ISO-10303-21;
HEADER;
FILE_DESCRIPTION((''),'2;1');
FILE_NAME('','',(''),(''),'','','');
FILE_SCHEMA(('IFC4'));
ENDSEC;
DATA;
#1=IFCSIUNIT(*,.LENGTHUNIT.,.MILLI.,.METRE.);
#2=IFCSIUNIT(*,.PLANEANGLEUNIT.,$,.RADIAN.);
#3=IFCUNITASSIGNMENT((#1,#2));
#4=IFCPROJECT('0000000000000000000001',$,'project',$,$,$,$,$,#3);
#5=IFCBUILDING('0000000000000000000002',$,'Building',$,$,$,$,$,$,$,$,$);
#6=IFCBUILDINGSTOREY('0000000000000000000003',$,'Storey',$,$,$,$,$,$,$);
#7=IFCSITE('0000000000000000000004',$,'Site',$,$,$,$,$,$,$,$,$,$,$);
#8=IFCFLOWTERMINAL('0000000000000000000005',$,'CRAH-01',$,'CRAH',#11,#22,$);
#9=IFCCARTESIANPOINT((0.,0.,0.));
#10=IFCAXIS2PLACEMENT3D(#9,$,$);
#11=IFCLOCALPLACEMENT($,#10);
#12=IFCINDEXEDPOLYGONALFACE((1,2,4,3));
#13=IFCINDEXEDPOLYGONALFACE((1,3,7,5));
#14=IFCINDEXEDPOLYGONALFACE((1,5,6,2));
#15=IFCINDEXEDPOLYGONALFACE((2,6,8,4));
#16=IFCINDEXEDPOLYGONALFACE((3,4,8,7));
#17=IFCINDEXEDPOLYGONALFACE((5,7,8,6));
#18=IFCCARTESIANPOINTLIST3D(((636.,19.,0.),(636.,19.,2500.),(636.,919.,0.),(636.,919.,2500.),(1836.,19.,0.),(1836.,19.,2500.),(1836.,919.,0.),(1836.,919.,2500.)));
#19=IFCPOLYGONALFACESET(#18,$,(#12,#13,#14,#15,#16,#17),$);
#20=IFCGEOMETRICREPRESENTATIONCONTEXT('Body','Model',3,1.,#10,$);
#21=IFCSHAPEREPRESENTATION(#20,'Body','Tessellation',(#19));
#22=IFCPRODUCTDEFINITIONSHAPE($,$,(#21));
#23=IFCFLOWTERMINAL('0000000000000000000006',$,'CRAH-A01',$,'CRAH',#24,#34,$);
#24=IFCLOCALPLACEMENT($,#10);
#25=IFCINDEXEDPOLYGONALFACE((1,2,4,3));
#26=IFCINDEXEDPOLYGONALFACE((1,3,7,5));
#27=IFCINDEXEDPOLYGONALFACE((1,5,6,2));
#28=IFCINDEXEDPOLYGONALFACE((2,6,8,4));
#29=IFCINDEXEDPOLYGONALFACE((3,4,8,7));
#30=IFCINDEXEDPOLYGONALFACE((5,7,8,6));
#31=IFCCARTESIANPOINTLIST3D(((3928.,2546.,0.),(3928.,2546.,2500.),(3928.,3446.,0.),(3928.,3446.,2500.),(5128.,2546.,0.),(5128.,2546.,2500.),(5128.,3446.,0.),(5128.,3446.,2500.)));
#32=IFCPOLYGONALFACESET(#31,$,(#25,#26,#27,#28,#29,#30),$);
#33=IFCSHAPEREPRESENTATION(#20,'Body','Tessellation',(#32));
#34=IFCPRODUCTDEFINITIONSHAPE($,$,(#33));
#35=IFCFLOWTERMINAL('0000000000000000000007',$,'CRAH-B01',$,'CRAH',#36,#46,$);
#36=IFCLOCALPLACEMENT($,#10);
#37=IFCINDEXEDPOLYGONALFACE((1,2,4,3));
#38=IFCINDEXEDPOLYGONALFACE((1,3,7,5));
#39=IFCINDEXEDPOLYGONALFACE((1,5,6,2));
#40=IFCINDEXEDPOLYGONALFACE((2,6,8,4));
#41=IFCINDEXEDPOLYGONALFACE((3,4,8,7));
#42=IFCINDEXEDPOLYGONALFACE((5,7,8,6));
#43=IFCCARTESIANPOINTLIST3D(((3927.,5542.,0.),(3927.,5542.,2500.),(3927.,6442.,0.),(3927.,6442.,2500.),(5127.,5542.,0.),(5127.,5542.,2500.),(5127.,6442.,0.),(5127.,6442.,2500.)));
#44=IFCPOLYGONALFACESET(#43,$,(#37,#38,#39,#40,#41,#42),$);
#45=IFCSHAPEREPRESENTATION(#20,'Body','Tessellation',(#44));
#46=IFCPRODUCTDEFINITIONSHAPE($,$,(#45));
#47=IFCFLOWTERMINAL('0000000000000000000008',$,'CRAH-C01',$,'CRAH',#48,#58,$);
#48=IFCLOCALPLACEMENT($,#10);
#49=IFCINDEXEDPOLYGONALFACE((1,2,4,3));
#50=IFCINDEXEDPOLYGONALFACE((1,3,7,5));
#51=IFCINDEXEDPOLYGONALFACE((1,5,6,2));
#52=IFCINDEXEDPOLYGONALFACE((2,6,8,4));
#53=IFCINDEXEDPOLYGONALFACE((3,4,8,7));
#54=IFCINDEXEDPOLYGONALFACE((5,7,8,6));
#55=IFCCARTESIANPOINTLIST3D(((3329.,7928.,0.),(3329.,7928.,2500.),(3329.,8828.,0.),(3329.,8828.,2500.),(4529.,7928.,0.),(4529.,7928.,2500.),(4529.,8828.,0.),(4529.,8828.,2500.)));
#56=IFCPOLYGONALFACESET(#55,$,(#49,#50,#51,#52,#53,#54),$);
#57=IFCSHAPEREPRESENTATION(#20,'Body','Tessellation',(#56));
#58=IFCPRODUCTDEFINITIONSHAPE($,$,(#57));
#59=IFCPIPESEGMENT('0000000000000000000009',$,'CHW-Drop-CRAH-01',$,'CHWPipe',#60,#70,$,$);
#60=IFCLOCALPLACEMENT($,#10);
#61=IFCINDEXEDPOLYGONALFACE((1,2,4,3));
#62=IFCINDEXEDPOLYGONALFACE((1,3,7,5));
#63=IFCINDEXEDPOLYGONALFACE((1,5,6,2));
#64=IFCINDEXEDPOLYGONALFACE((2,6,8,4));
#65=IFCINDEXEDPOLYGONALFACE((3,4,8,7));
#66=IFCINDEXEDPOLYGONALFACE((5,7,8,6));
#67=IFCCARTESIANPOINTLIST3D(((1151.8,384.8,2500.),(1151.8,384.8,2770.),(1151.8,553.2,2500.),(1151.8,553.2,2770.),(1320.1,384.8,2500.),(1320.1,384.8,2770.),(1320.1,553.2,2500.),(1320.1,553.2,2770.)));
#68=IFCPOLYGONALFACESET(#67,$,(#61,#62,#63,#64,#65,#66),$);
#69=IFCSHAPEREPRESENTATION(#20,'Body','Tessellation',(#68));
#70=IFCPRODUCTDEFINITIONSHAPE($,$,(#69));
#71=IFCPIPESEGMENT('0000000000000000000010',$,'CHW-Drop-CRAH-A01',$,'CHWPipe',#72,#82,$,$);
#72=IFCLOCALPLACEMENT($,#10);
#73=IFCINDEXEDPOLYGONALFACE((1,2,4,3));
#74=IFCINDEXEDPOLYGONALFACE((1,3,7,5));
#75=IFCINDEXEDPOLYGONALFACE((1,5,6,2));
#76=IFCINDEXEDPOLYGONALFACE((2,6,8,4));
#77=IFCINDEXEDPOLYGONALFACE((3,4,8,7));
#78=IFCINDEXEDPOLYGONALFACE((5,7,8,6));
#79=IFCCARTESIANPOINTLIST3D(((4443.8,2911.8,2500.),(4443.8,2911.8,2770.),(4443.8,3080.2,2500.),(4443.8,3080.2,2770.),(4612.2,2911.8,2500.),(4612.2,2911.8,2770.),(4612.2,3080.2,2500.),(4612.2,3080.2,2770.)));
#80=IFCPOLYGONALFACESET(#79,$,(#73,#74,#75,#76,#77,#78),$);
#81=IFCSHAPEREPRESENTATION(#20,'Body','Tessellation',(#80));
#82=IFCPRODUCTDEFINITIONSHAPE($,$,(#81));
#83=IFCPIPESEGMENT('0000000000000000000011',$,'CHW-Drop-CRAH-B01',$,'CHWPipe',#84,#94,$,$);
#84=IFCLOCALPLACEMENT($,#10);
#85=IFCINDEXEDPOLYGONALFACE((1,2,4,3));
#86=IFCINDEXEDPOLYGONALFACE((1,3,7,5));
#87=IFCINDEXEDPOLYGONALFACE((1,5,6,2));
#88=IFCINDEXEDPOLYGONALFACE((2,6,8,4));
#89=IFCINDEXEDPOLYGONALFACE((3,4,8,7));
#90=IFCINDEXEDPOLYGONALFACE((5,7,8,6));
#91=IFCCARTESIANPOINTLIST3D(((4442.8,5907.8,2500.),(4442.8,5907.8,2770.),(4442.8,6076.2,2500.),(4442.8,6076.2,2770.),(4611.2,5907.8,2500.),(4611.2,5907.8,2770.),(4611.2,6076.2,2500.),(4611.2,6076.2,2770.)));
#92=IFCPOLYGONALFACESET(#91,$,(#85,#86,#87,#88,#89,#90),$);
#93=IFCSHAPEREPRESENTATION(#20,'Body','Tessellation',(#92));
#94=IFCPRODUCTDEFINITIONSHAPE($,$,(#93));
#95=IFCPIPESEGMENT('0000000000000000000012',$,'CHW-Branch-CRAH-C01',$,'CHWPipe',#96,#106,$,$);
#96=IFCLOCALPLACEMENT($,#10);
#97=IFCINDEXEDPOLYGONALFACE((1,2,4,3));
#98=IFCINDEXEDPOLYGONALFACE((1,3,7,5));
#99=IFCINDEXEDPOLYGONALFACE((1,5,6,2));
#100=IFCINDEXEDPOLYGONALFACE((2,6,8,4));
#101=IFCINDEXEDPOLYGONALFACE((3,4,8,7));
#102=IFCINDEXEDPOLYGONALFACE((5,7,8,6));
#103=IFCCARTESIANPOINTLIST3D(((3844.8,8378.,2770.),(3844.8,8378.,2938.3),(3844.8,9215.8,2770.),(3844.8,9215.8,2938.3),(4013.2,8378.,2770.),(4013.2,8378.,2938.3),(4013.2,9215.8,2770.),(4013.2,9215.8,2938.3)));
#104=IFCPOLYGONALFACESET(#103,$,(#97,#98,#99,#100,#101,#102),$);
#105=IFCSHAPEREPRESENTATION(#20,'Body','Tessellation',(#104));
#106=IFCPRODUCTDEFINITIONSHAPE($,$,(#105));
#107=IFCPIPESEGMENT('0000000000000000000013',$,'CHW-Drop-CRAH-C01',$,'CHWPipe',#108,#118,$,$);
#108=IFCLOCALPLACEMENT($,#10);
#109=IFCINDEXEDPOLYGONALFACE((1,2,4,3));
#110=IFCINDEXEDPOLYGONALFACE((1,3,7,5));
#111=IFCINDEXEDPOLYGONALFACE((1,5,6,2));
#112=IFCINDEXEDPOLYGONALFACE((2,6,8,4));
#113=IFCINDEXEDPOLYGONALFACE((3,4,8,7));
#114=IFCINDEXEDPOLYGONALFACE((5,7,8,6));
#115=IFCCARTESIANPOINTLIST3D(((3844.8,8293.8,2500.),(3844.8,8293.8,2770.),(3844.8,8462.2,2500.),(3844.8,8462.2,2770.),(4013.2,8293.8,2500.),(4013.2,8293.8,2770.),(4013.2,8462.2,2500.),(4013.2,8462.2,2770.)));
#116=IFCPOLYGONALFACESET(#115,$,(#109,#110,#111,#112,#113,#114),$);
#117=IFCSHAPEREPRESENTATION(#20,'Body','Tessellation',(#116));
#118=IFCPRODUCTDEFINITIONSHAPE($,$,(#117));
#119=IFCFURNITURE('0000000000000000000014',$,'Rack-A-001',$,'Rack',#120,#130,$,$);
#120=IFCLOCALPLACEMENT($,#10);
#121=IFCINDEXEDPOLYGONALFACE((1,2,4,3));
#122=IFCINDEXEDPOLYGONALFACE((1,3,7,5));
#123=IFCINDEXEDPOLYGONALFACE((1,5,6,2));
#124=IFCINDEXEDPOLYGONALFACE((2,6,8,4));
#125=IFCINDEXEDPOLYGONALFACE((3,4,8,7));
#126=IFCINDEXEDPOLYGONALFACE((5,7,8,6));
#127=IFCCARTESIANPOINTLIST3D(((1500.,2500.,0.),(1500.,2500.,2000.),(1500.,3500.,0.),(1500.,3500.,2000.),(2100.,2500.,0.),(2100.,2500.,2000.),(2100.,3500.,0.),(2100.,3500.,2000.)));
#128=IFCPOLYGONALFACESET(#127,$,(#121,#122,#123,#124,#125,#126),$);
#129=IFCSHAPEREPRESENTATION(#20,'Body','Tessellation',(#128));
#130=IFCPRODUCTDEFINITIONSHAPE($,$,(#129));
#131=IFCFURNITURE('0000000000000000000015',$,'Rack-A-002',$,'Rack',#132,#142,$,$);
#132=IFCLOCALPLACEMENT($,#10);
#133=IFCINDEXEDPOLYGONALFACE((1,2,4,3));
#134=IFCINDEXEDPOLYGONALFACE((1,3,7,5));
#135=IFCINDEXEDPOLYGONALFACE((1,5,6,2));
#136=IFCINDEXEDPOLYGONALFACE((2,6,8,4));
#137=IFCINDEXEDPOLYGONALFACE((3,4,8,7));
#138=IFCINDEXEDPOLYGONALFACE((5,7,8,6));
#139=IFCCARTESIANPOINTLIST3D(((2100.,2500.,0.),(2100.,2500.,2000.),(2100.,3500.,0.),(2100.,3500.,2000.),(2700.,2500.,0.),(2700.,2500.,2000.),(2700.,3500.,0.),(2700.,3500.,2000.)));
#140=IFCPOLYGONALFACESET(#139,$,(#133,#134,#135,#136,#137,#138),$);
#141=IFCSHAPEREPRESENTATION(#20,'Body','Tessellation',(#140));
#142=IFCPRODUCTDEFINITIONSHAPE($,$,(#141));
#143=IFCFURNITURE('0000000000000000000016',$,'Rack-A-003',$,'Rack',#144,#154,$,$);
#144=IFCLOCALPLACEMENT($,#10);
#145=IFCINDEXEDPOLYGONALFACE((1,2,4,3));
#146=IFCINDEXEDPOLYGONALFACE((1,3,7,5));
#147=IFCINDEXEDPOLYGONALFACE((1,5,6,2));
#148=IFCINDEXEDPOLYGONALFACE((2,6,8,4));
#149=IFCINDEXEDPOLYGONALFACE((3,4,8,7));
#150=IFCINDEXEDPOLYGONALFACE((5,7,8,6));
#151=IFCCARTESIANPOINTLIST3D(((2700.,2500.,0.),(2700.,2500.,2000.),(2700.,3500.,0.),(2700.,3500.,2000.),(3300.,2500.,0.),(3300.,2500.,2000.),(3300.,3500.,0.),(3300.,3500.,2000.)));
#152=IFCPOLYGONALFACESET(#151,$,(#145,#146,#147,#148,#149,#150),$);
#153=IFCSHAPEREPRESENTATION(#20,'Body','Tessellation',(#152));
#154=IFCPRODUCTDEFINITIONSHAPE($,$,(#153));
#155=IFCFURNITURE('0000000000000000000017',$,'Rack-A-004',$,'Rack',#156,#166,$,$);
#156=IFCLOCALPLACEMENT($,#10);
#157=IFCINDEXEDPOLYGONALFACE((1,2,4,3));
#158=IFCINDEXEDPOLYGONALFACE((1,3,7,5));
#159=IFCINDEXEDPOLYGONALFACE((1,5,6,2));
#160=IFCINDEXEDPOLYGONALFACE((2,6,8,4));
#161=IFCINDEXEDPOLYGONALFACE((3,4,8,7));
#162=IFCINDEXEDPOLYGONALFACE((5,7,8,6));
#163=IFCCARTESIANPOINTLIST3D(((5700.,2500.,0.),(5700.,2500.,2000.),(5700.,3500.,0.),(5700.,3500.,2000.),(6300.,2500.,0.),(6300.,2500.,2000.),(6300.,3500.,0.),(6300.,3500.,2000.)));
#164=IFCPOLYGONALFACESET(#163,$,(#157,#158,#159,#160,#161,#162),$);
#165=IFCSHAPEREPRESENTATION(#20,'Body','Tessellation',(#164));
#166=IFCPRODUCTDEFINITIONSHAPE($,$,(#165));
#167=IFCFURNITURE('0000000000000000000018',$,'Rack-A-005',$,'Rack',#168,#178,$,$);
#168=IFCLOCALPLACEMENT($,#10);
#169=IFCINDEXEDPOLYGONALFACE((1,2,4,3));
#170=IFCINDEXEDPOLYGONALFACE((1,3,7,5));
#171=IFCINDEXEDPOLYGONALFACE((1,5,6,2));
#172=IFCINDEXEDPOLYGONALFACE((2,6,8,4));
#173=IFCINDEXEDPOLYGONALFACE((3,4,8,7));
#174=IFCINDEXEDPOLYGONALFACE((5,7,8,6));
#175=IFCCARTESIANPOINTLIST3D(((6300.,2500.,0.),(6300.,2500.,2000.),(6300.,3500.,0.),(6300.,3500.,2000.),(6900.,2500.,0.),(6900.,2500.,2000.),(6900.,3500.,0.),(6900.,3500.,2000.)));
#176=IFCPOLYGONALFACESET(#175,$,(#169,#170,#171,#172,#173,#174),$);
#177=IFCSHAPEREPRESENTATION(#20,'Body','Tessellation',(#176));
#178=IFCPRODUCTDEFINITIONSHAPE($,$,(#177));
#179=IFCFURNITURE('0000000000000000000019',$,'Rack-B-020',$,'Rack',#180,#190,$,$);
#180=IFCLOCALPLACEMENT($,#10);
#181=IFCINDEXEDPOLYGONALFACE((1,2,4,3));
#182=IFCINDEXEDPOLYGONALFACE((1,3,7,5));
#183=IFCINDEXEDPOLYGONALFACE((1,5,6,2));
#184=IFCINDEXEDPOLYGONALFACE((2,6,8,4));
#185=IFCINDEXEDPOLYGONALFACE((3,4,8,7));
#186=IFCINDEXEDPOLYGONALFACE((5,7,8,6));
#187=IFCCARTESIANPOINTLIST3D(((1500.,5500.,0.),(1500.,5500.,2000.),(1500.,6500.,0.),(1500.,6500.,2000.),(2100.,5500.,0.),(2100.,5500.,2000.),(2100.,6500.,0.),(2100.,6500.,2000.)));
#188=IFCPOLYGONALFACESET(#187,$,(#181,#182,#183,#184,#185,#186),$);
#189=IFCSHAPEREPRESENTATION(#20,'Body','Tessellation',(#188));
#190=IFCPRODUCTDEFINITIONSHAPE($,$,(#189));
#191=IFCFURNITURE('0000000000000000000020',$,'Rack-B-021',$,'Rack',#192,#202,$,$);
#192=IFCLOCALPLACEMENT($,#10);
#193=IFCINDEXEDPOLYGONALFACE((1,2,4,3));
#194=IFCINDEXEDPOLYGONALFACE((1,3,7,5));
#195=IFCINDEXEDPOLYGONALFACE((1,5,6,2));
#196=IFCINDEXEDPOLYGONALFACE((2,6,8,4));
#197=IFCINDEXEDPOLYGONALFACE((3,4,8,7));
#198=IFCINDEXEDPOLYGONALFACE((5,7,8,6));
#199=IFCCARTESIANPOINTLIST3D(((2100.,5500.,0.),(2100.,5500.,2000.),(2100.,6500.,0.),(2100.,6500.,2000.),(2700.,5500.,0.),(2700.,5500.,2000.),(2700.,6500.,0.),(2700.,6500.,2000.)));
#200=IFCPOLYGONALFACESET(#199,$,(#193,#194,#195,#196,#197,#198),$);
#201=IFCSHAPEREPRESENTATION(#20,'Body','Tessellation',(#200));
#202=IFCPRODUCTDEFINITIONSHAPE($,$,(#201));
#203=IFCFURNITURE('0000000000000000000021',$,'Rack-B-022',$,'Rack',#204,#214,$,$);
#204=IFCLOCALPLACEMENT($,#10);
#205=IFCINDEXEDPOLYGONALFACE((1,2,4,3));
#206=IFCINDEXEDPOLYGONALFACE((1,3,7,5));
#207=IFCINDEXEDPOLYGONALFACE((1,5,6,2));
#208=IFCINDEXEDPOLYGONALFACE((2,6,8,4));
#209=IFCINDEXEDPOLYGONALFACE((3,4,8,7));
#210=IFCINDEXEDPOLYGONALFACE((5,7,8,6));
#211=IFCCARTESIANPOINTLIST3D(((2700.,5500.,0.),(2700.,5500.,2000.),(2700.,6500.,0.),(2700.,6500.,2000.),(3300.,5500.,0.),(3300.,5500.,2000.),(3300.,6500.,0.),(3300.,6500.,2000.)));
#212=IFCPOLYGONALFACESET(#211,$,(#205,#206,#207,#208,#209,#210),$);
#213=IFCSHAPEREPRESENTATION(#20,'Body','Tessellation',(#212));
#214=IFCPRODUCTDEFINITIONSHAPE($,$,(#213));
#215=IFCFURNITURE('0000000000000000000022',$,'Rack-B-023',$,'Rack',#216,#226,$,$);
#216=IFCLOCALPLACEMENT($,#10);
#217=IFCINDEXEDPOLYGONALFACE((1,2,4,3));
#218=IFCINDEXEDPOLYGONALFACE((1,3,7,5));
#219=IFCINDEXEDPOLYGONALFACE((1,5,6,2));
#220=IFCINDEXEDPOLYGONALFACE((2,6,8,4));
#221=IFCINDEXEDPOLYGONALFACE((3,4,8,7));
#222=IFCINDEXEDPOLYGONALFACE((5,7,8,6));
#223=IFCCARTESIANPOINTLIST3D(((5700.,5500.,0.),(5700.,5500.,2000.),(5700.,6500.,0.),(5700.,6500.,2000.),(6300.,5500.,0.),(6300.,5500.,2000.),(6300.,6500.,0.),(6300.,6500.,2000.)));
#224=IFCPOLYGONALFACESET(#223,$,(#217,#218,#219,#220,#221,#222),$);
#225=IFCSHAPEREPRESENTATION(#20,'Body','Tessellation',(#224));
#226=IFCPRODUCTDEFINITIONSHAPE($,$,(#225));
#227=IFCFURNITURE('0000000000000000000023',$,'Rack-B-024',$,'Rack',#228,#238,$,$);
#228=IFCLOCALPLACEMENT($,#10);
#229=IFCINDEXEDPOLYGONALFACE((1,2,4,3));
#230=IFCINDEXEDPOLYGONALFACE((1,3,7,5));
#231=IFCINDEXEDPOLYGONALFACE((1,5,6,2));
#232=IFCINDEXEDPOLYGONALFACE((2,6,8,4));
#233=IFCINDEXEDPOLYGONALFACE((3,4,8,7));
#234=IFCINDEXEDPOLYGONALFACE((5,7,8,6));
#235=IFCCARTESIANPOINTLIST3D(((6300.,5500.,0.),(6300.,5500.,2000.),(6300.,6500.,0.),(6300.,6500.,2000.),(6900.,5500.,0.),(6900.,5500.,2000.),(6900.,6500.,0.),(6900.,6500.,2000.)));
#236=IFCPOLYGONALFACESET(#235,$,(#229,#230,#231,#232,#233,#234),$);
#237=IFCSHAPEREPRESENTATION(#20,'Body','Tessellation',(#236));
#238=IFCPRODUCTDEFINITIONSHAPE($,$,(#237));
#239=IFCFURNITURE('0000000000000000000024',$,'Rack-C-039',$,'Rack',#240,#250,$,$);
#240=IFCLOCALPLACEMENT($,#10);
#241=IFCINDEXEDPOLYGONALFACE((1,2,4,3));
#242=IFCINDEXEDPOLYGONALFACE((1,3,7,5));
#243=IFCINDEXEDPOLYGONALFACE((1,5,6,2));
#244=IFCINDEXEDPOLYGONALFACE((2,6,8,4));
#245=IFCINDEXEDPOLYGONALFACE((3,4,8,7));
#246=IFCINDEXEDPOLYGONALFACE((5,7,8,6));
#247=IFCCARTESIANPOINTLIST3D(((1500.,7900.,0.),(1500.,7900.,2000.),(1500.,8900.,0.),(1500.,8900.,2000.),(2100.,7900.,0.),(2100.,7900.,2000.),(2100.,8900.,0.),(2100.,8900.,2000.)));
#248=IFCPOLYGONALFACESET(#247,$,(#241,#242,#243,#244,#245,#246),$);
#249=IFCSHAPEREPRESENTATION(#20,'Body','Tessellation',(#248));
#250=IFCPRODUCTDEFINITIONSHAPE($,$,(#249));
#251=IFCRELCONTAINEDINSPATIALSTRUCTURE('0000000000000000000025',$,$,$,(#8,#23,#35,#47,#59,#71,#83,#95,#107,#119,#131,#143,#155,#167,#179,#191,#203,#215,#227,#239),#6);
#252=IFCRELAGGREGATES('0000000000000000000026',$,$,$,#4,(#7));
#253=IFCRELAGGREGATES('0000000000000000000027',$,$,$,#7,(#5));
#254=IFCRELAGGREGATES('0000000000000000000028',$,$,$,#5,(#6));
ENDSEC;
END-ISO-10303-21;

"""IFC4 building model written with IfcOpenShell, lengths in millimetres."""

from ifc_helpers import new_model, si_unit, frame, origin, place, context, project, spatial, rectangle, extrude, element, save


model = new_model("IFC4")

# Units and contexts
model_context = context("Model", 3, precision=1.0, world=origin(), identifier="Body")
ifc_project = project(units=[si_unit("LENGTHUNIT", "METRE", prefix="MILLI"), si_unit("PLANEANGLEUNIT", "RADIAN")])

# Site, building, storey
site = spatial("IfcSite", under=ifc_project, Name="Site")
building = spatial("IfcBuilding", under=site, Name="Building")
storey = spatial("IfcBuildingStorey", under=building, Name="Storey")

# Flow terminals
for number, where, z_axis, x_axis, name in (
    (1, (1236.0, 469.0, 0.0), (0.0, 0.0, 1.0), (1.0, 0.0, 0.0), "CRAH-01"),
    (2, (4528.0, 2996.0, 0.0), (0.0, 0.0, 1.0), (1.0, 0.0, 0.0), "CRAH-A01"),
    (3, (4527.0, 5992.0, 0.0), (0.0, 0.0, 1.0), (1.0, 0.0, 0.0), "CRAH-B01"),
    (4, (3929.0, 8378.0, 0.0), (0.0, 0.0, 1.0), (1.0, 0.0, 0.0), "CRAH-C01"),
):
    element("IfcFlowTerminal", number, at=place(None, frame(where, z_axis=z_axis, x_axis=x_axis)), inside=storey, Name=name, ObjectType="CRAH", context=model_context, shape_type="SweptSolid", body=[
        extrude(rectangle(XDim=1200.0, YDim=900.0), origin(), (0.0, 0.0, 1.0), 2500.0),
    ])

# Pipe segments
for number, where, z_axis, x_axis, name in (
    (5, (1236.0, 469.0, 2500.0), (0.0, 0.0, 1.0), (1.0, 0.0, 0.0), "CHW-Drop-CRAH-01"),
    (6, (4528.0, 2996.0, 2500.0), (0.0, 0.0, 1.0), (1.0, 0.0, 0.0), "CHW-Drop-CRAH-A01"),
    (7, (4527.0, 5992.0, 2500.0), (0.0, 0.0, 1.0), (1.0, 0.0, 0.0), "CHW-Drop-CRAH-B01"),
):
    element("IfcPipeSegment", number, at=place(None, frame(where, z_axis=z_axis, x_axis=x_axis)), inside=storey, Name=name, ObjectType="CHWPipe", context=model_context, shape_type="SweptSolid", body=[
        extrude(rectangle(XDim=168.3, YDim=168.3), origin(), (0.0, 0.0, 1.0), 270.0),
    ])
pipe_segment_1_placement = place(None, frame((3929.0, 8796.9, 2770.0), z_axis=(0.0, 0.0, 1.0), x_axis=(1.0, 0.0, 0.0)))
element("IfcPipeSegment", 8, at=pipe_segment_1_placement, inside=storey, Name="CHW-Branch-CRAH-C01", ObjectType="CHWPipe", context=model_context, shape_type="SweptSolid", body=[
    extrude(rectangle(XDim=168.3, YDim=837.9), origin(), (0.0, 0.0, 1.0), 168.3),
])
pipe_segment_2_placement = place(None, frame((3929.0, 8378.0, 2500.0), z_axis=(0.0, 0.0, 1.0), x_axis=(1.0, 0.0, 0.0)))
element("IfcPipeSegment", 9, at=pipe_segment_2_placement, inside=storey, Name="CHW-Drop-CRAH-C01", ObjectType="CHWPipe", context=model_context, shape_type="SweptSolid", body=[
    extrude(rectangle(XDim=168.3, YDim=168.3), origin(), (0.0, 0.0, 1.0), 270.0),
])

# Furniture
for number, where, z_axis, x_axis, name in (
    (10, (1800.0, 3000.0, 0.0), (0.0, 0.0, 1.0), (1.0, 0.0, 0.0), "Rack-A-001"),
    (11, (2400.0, 3000.0, 0.0), (0.0, 0.0, 1.0), (1.0, 0.0, 0.0), "Rack-A-002"),
    (12, (3000.0, 3000.0, 0.0), (0.0, 0.0, 1.0), (1.0, 0.0, 0.0), "Rack-A-003"),
    (13, (6000.0, 3000.0, 0.0), (0.0, 0.0, 1.0), (1.0, 0.0, 0.0), "Rack-A-004"),
    (14, (6600.0, 3000.0, 0.0), (0.0, 0.0, 1.0), (1.0, 0.0, 0.0), "Rack-A-005"),
    (15, (1800.0, 6000.0, 0.0), (0.0, 0.0, 1.0), (1.0, 0.0, 0.0), "Rack-B-020"),
    (16, (2400.0, 6000.0, 0.0), (0.0, 0.0, 1.0), (1.0, 0.0, 0.0), "Rack-B-021"),
    (17, (3000.0, 6000.0, 0.0), (0.0, 0.0, 1.0), (1.0, 0.0, 0.0), "Rack-B-022"),
    (18, (6000.0, 6000.0, 0.0), (0.0, 0.0, 1.0), (1.0, 0.0, 0.0), "Rack-B-023"),
    (19, (6600.0, 6000.0, 0.0), (0.0, 0.0, 1.0), (1.0, 0.0, 0.0), "Rack-B-024"),
    (20, (1800.0, 8400.0, 0.0), (0.0, 0.0, 1.0), (1.0, 0.0, 0.0), "Rack-C-039"),
):
    element("IfcFurniture", number, at=place(None, frame(where, z_axis=z_axis, x_axis=x_axis)), inside=storey, Name=name, ObjectType="Rack", context=model_context, shape_type="SweptSolid", body=[
        extrude(rectangle(XDim=600.0, YDim=1000.0), origin(), (0.0, 0.0, 1.0), 2000.0),
    ])

save(model, "model.ifc")
